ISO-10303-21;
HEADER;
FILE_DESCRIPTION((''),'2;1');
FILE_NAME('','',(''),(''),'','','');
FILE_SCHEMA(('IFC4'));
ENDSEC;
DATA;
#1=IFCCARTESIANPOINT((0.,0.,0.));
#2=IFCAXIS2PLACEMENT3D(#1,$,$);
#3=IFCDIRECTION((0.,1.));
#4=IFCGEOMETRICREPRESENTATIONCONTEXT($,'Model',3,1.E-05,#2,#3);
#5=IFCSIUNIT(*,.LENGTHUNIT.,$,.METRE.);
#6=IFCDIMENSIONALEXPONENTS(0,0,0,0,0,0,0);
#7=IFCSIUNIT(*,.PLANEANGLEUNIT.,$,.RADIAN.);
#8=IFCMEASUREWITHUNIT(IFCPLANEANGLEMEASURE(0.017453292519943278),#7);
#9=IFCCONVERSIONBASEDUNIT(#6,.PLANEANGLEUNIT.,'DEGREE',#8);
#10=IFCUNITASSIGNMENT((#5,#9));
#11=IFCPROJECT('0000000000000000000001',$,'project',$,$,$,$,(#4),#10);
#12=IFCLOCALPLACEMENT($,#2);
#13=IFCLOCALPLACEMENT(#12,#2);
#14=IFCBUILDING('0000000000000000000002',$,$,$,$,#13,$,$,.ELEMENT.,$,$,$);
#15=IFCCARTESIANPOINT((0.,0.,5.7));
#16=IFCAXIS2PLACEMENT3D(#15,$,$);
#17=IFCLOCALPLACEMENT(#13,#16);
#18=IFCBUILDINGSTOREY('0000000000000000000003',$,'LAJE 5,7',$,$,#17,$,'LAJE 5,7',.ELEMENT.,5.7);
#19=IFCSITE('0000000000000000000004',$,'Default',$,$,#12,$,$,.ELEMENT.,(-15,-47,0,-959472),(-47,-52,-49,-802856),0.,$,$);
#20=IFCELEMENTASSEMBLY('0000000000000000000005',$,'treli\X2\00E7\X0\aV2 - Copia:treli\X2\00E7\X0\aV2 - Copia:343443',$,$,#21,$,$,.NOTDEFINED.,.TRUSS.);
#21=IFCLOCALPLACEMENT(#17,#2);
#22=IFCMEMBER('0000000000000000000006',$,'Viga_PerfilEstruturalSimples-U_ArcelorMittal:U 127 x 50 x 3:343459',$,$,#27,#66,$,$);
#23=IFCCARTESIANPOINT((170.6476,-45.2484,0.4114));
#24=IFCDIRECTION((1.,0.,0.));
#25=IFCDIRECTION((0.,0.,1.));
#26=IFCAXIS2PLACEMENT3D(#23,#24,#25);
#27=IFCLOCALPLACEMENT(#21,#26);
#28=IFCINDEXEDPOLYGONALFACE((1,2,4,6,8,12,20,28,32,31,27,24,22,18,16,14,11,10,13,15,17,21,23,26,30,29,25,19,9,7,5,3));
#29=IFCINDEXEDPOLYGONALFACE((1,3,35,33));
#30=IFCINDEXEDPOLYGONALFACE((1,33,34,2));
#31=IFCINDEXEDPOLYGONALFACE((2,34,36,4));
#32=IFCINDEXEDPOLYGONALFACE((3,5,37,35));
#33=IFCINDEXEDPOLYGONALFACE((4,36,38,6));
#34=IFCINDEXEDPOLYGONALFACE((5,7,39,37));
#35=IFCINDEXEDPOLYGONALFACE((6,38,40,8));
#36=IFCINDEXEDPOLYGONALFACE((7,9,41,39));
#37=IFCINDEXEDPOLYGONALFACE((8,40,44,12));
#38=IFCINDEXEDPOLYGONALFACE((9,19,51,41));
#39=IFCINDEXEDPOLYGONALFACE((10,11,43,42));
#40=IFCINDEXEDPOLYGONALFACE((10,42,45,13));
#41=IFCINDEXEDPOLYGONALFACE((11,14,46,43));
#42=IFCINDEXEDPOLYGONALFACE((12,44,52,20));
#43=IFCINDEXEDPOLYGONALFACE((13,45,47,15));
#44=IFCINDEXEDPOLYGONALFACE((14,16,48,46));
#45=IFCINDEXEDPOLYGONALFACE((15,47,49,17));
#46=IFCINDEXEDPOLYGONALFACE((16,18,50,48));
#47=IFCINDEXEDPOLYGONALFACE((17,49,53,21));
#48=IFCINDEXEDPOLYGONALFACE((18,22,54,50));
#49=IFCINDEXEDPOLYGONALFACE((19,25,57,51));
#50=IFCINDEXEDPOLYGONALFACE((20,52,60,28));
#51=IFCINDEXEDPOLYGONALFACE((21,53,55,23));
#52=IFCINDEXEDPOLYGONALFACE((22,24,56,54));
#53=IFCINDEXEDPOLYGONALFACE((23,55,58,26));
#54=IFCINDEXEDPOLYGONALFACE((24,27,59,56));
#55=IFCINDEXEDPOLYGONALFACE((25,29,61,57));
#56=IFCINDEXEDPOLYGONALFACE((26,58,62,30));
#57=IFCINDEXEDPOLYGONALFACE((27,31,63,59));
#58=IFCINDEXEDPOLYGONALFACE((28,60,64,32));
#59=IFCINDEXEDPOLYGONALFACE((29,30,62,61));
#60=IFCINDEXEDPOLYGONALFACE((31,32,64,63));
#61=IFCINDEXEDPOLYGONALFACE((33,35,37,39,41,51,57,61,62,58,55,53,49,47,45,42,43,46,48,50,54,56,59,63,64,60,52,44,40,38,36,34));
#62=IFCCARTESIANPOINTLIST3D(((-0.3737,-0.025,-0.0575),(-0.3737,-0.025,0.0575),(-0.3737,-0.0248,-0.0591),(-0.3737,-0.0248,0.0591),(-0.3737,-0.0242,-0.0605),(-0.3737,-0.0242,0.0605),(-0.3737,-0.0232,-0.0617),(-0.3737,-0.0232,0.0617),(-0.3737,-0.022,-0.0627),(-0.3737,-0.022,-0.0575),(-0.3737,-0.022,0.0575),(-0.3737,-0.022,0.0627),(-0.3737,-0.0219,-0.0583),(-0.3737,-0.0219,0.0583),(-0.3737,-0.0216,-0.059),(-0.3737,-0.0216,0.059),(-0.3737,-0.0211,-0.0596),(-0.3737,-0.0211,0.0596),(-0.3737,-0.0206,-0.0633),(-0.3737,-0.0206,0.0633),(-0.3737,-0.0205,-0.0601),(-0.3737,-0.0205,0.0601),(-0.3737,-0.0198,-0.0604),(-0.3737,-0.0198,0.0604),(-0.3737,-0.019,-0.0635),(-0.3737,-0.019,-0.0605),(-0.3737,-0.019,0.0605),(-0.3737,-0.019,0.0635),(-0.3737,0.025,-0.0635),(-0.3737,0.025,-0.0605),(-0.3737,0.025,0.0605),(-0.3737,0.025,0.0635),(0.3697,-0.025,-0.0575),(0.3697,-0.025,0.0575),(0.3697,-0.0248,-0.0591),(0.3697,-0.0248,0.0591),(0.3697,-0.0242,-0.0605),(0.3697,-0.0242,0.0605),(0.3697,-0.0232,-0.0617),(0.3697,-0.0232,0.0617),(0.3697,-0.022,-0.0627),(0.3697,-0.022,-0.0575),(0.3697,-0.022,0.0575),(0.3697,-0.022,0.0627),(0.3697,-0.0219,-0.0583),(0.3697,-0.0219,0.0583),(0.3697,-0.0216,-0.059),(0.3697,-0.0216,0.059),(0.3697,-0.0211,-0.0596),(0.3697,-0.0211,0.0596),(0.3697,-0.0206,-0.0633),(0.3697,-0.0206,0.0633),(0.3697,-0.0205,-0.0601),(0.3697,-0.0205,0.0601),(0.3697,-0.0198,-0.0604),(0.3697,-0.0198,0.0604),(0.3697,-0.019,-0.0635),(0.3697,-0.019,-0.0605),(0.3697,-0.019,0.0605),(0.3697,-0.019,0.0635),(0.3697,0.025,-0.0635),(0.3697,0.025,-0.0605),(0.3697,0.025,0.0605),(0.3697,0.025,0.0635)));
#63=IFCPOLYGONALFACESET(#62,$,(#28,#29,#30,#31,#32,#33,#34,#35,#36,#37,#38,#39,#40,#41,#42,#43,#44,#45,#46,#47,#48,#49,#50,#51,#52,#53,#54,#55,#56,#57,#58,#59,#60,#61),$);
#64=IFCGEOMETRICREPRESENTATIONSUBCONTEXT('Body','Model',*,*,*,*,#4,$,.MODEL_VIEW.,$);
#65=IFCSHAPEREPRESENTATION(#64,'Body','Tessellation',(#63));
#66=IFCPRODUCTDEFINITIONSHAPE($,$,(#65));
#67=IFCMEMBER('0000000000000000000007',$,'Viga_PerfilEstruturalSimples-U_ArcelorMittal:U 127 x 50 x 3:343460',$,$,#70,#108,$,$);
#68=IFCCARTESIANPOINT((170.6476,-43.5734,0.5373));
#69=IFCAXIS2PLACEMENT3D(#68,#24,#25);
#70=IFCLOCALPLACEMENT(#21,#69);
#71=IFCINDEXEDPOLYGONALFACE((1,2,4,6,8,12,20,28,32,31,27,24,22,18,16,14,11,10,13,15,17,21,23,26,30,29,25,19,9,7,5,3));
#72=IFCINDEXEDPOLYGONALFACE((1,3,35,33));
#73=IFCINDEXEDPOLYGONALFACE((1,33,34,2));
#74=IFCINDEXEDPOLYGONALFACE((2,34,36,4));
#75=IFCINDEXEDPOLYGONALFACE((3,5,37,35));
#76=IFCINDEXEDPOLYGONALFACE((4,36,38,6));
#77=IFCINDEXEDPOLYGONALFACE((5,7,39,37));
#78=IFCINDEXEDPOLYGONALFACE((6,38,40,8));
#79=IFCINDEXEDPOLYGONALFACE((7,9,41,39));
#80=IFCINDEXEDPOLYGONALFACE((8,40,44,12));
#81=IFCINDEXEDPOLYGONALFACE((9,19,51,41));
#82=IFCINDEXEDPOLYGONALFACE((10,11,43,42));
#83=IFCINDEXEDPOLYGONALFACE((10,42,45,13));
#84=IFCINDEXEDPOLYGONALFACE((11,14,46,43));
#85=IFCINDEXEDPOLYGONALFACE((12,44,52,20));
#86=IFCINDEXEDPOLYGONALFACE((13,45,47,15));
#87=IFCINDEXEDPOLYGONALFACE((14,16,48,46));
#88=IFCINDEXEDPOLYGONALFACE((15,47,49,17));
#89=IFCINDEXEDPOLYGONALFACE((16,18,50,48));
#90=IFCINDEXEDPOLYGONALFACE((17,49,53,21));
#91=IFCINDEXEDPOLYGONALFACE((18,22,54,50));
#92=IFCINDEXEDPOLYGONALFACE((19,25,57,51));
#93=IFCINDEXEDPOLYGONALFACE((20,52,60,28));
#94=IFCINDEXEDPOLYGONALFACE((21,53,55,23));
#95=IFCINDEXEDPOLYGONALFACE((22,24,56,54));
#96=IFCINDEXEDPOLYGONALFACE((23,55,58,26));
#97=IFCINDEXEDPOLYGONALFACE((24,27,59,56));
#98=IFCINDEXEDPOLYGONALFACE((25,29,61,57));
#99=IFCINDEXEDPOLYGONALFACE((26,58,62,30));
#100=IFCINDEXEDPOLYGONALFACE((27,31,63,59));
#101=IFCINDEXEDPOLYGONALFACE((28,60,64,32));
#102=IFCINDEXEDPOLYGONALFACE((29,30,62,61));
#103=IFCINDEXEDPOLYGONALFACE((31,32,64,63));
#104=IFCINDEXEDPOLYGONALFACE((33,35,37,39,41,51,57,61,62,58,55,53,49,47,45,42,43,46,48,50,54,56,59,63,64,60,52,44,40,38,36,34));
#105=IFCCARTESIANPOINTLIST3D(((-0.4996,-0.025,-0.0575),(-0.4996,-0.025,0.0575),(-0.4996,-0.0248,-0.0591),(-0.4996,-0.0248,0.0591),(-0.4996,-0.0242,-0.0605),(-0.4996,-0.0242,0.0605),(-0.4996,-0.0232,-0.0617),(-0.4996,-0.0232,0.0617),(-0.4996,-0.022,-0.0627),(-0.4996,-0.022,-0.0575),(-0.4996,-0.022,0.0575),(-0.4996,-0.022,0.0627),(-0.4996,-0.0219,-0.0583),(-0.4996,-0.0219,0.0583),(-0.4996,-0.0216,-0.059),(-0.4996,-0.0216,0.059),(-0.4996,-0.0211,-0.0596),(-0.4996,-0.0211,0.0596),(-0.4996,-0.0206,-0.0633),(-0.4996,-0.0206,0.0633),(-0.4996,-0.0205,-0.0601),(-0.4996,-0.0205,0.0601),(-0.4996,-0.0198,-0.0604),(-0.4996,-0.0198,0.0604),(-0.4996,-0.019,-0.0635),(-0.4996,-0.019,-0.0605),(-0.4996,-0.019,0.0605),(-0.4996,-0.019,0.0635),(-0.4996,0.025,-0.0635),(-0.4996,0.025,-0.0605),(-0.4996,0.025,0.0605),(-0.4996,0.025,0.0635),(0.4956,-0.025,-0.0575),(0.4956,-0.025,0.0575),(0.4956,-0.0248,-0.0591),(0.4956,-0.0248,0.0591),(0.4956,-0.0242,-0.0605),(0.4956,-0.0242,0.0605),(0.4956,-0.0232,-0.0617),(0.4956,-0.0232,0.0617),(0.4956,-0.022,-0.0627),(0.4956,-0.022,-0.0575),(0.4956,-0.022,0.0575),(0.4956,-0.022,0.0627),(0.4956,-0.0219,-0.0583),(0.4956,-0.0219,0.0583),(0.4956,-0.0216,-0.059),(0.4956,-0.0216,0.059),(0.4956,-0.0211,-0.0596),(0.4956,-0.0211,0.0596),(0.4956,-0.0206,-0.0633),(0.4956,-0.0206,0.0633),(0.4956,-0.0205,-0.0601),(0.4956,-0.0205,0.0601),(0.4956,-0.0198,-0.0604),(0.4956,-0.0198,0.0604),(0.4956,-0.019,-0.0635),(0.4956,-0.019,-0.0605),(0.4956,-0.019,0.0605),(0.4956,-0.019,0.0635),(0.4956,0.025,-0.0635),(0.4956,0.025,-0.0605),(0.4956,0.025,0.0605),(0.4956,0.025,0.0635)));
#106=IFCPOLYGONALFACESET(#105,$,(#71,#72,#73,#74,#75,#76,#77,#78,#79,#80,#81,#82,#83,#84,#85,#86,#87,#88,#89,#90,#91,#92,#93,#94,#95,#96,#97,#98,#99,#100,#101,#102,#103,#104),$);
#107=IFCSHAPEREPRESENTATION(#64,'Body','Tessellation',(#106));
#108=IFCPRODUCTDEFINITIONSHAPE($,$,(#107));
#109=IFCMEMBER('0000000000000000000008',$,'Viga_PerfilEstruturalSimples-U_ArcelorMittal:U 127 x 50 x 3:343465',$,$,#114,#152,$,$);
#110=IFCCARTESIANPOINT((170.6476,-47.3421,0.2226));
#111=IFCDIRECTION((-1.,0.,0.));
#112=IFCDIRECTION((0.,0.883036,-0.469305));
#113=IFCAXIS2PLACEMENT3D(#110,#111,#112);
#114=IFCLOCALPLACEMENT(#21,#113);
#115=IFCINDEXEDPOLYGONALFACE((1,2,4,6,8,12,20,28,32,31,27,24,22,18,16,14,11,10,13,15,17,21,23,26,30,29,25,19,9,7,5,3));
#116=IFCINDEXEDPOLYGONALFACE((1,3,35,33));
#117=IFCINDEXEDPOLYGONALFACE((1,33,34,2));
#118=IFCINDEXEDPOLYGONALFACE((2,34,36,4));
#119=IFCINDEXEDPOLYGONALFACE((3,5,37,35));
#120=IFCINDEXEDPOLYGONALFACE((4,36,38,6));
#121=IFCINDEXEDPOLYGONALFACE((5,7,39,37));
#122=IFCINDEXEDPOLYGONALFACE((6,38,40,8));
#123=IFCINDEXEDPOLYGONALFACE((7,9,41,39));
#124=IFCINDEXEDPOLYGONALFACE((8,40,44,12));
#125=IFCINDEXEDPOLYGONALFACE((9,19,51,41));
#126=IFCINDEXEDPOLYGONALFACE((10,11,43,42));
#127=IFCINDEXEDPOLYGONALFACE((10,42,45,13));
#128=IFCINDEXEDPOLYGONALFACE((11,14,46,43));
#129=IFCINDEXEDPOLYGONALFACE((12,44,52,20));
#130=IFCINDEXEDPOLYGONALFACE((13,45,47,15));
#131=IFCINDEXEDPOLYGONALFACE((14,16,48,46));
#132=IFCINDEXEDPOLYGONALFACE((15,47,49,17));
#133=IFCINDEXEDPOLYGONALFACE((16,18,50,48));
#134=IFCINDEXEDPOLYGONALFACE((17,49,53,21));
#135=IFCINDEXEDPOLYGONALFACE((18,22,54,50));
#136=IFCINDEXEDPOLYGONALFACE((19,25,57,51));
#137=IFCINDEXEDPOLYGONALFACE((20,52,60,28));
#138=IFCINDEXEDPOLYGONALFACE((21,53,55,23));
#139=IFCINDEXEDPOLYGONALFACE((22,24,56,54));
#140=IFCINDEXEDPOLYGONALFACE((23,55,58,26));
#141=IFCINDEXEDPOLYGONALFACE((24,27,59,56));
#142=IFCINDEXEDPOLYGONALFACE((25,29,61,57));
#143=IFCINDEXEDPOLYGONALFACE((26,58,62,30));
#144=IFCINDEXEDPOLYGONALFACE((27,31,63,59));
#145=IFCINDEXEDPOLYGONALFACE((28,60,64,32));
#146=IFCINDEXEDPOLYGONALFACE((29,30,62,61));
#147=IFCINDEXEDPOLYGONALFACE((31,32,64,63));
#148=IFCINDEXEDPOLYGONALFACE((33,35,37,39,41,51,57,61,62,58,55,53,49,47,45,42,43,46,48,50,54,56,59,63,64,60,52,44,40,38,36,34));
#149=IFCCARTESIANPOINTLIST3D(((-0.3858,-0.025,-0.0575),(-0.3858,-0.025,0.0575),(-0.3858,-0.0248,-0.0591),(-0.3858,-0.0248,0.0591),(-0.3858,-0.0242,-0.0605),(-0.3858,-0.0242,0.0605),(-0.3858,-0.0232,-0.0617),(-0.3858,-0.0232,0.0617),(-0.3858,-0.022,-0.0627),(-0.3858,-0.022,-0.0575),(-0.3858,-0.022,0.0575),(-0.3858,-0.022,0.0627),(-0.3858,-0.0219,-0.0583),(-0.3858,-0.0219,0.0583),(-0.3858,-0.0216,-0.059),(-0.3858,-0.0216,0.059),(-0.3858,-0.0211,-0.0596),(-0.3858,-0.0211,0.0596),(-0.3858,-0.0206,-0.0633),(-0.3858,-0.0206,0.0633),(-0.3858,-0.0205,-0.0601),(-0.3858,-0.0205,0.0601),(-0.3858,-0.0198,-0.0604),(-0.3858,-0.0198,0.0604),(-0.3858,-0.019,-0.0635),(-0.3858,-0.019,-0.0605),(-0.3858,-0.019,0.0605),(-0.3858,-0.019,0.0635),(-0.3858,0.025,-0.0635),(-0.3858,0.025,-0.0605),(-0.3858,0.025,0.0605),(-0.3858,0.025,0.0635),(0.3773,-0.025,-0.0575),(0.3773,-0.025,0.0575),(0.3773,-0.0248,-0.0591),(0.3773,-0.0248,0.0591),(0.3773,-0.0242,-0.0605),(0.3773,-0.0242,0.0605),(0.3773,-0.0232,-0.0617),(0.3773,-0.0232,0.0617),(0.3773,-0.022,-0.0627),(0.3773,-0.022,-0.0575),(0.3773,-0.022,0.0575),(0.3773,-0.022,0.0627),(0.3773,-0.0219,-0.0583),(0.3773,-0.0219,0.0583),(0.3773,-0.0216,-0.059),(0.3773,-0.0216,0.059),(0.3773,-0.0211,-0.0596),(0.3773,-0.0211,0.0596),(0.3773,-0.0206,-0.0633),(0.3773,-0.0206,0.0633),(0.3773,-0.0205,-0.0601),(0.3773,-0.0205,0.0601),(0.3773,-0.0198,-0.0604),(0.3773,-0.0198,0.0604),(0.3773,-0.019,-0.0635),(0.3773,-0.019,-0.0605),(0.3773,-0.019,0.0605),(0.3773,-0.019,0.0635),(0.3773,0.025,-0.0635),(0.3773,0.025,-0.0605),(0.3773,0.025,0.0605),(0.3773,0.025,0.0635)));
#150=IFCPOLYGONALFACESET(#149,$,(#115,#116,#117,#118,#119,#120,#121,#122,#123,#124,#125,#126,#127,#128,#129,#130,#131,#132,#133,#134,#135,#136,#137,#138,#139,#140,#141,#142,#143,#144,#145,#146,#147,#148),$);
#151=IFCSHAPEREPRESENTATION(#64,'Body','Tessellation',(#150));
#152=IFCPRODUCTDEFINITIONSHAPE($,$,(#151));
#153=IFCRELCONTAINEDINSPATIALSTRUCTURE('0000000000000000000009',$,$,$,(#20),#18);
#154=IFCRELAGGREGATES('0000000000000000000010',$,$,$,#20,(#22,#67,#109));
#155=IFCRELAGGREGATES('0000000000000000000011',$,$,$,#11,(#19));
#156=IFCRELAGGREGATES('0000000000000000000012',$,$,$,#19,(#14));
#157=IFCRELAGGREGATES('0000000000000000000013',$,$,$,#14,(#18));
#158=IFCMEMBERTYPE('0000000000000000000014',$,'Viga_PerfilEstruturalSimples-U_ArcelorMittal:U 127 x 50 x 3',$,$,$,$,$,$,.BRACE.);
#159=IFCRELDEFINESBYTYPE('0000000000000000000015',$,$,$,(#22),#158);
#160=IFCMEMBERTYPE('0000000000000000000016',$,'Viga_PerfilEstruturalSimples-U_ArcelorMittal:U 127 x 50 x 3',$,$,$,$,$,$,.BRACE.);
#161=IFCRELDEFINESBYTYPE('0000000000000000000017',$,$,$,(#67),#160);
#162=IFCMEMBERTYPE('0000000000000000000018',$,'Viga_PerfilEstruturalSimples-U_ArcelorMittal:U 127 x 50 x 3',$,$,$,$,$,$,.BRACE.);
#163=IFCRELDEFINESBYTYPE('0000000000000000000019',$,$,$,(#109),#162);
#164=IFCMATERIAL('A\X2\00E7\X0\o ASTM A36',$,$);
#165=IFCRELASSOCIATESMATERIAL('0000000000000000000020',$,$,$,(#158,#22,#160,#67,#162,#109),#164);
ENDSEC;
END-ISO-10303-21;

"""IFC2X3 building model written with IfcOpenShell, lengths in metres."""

from ifc_helpers import new_model, entity, si_unit, converted_unit, direction, frame, frame_2d, origin, place, context, subcontext, project, spatial, polyline, circle_curve, parameter, trimmed, segment, composite_curve, outline, extrude, source, transform, mapped, material, type_object, type_shapes, element, aggregate, save


model = new_model("IFC2X3")

# Units and contexts
model_context = context("Model", 3, precision=1e-05, world=origin(), true_north=direction((0.0, 1.0)))
body_context = subcontext(model_context, "Body", "Model", "MODEL_VIEW")
ifc_project = project(units=[si_unit("LENGTHUNIT", "METRE"), converted_unit("PLANEANGLEUNIT", "DEGREE", entity("IfcPlaneAngleMeasure", 0.017453292519943278), si_unit("PLANEANGLEUNIT", "RADIAN"), dimensions=[0, 0, 0, 0, 0, 0, 0])], contexts=[model_context])

# Site, building, storey
site_placement = place(None, origin())
site = spatial("IfcSite", under=ifc_project, at=site_placement, Name="Default", CompositionType="ELEMENT", RefLatitude=(-15, -47, 0, -959472), RefLongitude=(-47, -52, -49, -802856), RefElevation=0.0)
building_placement = place(site_placement, origin())
building = spatial("IfcBuilding", under=site, at=building_placement, CompositionType="ELEMENT")
storey_placement = place(building_placement, frame((0.0, 0.0, 5.7)))
storey = spatial("IfcBuildingStorey", under=building, at=storey_placement, Name="LAJE 5,7", LongName="LAJE 5,7", CompositionType="ELEMENT", Elevation=5.7)

# Shared definitions
ifc_material = material(Name="Aço ASTM A36")

# Element assembly, member
assembly_1_placement = place(storey_placement, origin())
assembly_1 = element("IfcElementAssembly", 1, at=assembly_1_placement, inside=storey, Name="treliçaV2 - Copia:treliçaV2 - Copia:343443", AssemblyPlace="NOTDEFINED", PredefinedType="TRUSS")
member_type_1 = type_object("IfcMemberType", Name="Viga_PerfilEstruturalSimples-U_ArcelorMittal:U 127 x 50 x 3", PredefinedType="BRACE", material=ifc_material)
shared_shape_1 = source(origin(), body_context, "Body", "SweptSolid", [
    extrude(outline(composite_curve([segment(polyline([(-0.0575, -0.0192), (0.0575, -0.0192)]), True, "CONTINUOUS"), segment(trimmed(circle_curve(frame_2d((0.0575, -0.0132), x_axis=(0.0, 1.0)), 0.006), [parameter(180.0)], [parameter(270.0)], True, "PARAMETER"), True, "CONTINUOUS"), segment(polyline([(0.0635, -0.0132), (0.0635, 0.0308)]), True, "CONTINUOUS"), segment(polyline([(0.0635, 0.0308), (0.0605, 0.0308)]), True, "CONTINUOUS"), segment(polyline([(0.0605, 0.0308), (0.0605, -0.0132)]), True, "CONTINUOUS"), segment(trimmed(circle_curve(frame_2d((0.0575, -0.0132), x_axis=(0.0, 1.0)), 0.003), [parameter(180.0)], [parameter(270.0)], True, "PARAMETER"), False, "CONTINUOUS"), segment(polyline([(0.0575, -0.0162), (-0.0575, -0.0162)]), True, "CONTINUOUS"), segment(trimmed(circle_curve(frame_2d((-0.0575, -0.0132), x_axis=(0.0, 1.0)), 0.003), [parameter(90.0)], [parameter(180.0)], True, "PARAMETER"), False, "CONTINUOUS"), segment(polyline([(-0.0605, -0.0132), (-0.0605, 0.0308)]), True, "CONTINUOUS"), segment(polyline([(-0.0605, 0.0308), (-0.0635, 0.0308)]), True, "CONTINUOUS"), segment(polyline([(-0.0635, 0.0308), (-0.0635, -0.0132)]), True, "CONTINUOUS"), segment(trimmed(circle_curve(frame_2d((-0.0575, -0.0132), x_axis=(0.0, 1.0)), 0.006), [parameter(90.0)], [parameter(180.0)], True, "PARAMETER"), True, "CONTINUOUS")], self_intersect=False)), frame((-0.3737, -0.0058, 0.0), z_axis=(1.0, 0.0, 0.0), x_axis=(0.0, 0.0, -1.0)), (0.0, 0.0, 1.0), 0.7434),
])
type_shapes(member_type_1, [shared_shape_1])
member_1_placement = place(assembly_1_placement, frame((170.6476, -45.2484, 0.4114), z_axis=(1.0, 0.0, 0.0), x_axis=(0.0, 0.0, 1.0)))
member_1 = element("IfcMember", 2, at=member_1_placement, type_object=member_type_1, material=ifc_material, Name="Viga_PerfilEstruturalSimples-U_ArcelorMittal:U 127 x 50 x 3:343459", context=body_context, shape_type="MappedRepresentation", body=[
    mapped(shared_shape_1, transform((0.0, 0.0, 0.0), scale=1.0)),
])

# Members
member_type_2 = type_object("IfcMemberType", Name="Viga_PerfilEstruturalSimples-U_ArcelorMittal:U 127 x 50 x 3", PredefinedType="BRACE", material=ifc_material)
shared_shape_2 = source(origin(), body_context, "Body", "SweptSolid", [
    extrude(outline(composite_curve([segment(polyline([(-0.0575, -0.0192), (0.0575, -0.0192)]), True, "CONTINUOUS"), segment(trimmed(circle_curve(frame_2d((0.0575, -0.0132), x_axis=(0.0, 1.0)), 0.006), [parameter(180.0)], [parameter(270.0)], True, "PARAMETER"), True, "CONTINUOUS"), segment(polyline([(0.0635, -0.0132), (0.0635, 0.0308)]), True, "CONTINUOUS"), segment(polyline([(0.0635, 0.0308), (0.0605, 0.0308)]), True, "CONTINUOUS"), segment(polyline([(0.0605, 0.0308), (0.0605, -0.0132)]), True, "CONTINUOUS"), segment(trimmed(circle_curve(frame_2d((0.0575, -0.0132), x_axis=(0.0, 1.0)), 0.003), [parameter(180.0)], [parameter(270.0)], True, "PARAMETER"), False, "CONTINUOUS"), segment(polyline([(0.0575, -0.0162), (-0.0575, -0.0162)]), True, "CONTINUOUS"), segment(trimmed(circle_curve(frame_2d((-0.0575, -0.0132), x_axis=(0.0, 1.0)), 0.003), [parameter(90.0)], [parameter(180.0)], True, "PARAMETER"), False, "CONTINUOUS"), segment(polyline([(-0.0605, -0.0132), (-0.0605, 0.0308)]), True, "CONTINUOUS"), segment(polyline([(-0.0605, 0.0308), (-0.0635, 0.0308)]), True, "CONTINUOUS"), segment(polyline([(-0.0635, 0.0308), (-0.0635, -0.0132)]), True, "CONTINUOUS"), segment(trimmed(circle_curve(frame_2d((-0.0575, -0.0132), x_axis=(0.0, 1.0)), 0.006), [parameter(90.0)], [parameter(180.0)], True, "PARAMETER"), True, "CONTINUOUS")], self_intersect=False)), frame((-0.4996, -0.0058, 0.0), z_axis=(1.0, 0.0, 0.0), x_axis=(0.0, 0.0, -1.0)), (0.0, 0.0, 1.0), 0.9952),
])
type_shapes(member_type_2, [shared_shape_2])
member_2_placement = place(assembly_1_placement, frame((170.6476, -43.5734, 0.5373), z_axis=(1.0, 0.0, 0.0), x_axis=(0.0, 0.0, 1.0)))
member_2 = element("IfcMember", 3, at=member_2_placement, type_object=member_type_2, material=ifc_material, Name="Viga_PerfilEstruturalSimples-U_ArcelorMittal:U 127 x 50 x 3:343460", context=body_context, shape_type="MappedRepresentation", body=[
    mapped(shared_shape_2, transform((0.0, 0.0, 0.0), scale=1.0)),
])
member_type_3 = type_object("IfcMemberType", Name="Viga_PerfilEstruturalSimples-U_ArcelorMittal:U 127 x 50 x 3", PredefinedType="BRACE", material=ifc_material)
shared_shape_3 = source(origin(), body_context, "Body", "SweptSolid", [
    extrude(outline(composite_curve([segment(polyline([(-0.0575, -0.0192), (0.0575, -0.0192)]), True, "CONTINUOUS"), segment(trimmed(circle_curve(frame_2d((0.0575, -0.0132), x_axis=(0.0, 1.0)), 0.006), [parameter(180.0)], [parameter(270.0)], True, "PARAMETER"), True, "CONTINUOUS"), segment(polyline([(0.0635, -0.0132), (0.0635, 0.0308)]), True, "CONTINUOUS"), segment(polyline([(0.0635, 0.0308), (0.0605, 0.0308)]), True, "CONTINUOUS"), segment(polyline([(0.0605, 0.0308), (0.0605, -0.0132)]), True, "CONTINUOUS"), segment(trimmed(circle_curve(frame_2d((0.0575, -0.0132), x_axis=(0.0, 1.0)), 0.003), [parameter(180.0)], [parameter(270.0)], True, "PARAMETER"), False, "CONTINUOUS"), segment(polyline([(0.0575, -0.0162), (-0.0575, -0.0162)]), True, "CONTINUOUS"), segment(trimmed(circle_curve(frame_2d((-0.0575, -0.0132), x_axis=(0.0, 1.0)), 0.003), [parameter(90.0)], [parameter(180.0)], True, "PARAMETER"), False, "CONTINUOUS"), segment(polyline([(-0.0605, -0.0132), (-0.0605, 0.0308)]), True, "CONTINUOUS"), segment(polyline([(-0.0605, 0.0308), (-0.0635, 0.0308)]), True, "CONTINUOUS"), segment(polyline([(-0.0635, 0.0308), (-0.0635, -0.0132)]), True, "CONTINUOUS"), segment(trimmed(circle_curve(frame_2d((-0.0575, -0.0132), x_axis=(0.0, 1.0)), 0.006), [parameter(90.0)], [parameter(180.0)], True, "PARAMETER"), True, "CONTINUOUS")], self_intersect=False)), frame((-0.3858, -0.0058, 0.0), z_axis=(1.0, 0.0, 0.0), x_axis=(0.0, 0.0, -1.0)), (0.0, 0.0, 1.0), 0.7631),
])
type_shapes(member_type_3, [shared_shape_3])
member_3_placement = place(assembly_1_placement, frame((170.6476, -47.3421, 0.2226), z_axis=(-1.0, 0.0, 0.0), x_axis=(0.0, 0.883036, -0.469305)))
member_3 = element("IfcMember", 4, at=member_3_placement, type_object=member_type_3, material=ifc_material, Name="Viga_PerfilEstruturalSimples-U_ArcelorMittal:U 127 x 50 x 3:343465", context=body_context, shape_type="MappedRepresentation", body=[
    mapped(shared_shape_3, transform((0.0, 0.0, 0.0), scale=1.0)),
])
aggregate(assembly_1, [member_1, member_2, member_3])

save(model, "model.ifc")
